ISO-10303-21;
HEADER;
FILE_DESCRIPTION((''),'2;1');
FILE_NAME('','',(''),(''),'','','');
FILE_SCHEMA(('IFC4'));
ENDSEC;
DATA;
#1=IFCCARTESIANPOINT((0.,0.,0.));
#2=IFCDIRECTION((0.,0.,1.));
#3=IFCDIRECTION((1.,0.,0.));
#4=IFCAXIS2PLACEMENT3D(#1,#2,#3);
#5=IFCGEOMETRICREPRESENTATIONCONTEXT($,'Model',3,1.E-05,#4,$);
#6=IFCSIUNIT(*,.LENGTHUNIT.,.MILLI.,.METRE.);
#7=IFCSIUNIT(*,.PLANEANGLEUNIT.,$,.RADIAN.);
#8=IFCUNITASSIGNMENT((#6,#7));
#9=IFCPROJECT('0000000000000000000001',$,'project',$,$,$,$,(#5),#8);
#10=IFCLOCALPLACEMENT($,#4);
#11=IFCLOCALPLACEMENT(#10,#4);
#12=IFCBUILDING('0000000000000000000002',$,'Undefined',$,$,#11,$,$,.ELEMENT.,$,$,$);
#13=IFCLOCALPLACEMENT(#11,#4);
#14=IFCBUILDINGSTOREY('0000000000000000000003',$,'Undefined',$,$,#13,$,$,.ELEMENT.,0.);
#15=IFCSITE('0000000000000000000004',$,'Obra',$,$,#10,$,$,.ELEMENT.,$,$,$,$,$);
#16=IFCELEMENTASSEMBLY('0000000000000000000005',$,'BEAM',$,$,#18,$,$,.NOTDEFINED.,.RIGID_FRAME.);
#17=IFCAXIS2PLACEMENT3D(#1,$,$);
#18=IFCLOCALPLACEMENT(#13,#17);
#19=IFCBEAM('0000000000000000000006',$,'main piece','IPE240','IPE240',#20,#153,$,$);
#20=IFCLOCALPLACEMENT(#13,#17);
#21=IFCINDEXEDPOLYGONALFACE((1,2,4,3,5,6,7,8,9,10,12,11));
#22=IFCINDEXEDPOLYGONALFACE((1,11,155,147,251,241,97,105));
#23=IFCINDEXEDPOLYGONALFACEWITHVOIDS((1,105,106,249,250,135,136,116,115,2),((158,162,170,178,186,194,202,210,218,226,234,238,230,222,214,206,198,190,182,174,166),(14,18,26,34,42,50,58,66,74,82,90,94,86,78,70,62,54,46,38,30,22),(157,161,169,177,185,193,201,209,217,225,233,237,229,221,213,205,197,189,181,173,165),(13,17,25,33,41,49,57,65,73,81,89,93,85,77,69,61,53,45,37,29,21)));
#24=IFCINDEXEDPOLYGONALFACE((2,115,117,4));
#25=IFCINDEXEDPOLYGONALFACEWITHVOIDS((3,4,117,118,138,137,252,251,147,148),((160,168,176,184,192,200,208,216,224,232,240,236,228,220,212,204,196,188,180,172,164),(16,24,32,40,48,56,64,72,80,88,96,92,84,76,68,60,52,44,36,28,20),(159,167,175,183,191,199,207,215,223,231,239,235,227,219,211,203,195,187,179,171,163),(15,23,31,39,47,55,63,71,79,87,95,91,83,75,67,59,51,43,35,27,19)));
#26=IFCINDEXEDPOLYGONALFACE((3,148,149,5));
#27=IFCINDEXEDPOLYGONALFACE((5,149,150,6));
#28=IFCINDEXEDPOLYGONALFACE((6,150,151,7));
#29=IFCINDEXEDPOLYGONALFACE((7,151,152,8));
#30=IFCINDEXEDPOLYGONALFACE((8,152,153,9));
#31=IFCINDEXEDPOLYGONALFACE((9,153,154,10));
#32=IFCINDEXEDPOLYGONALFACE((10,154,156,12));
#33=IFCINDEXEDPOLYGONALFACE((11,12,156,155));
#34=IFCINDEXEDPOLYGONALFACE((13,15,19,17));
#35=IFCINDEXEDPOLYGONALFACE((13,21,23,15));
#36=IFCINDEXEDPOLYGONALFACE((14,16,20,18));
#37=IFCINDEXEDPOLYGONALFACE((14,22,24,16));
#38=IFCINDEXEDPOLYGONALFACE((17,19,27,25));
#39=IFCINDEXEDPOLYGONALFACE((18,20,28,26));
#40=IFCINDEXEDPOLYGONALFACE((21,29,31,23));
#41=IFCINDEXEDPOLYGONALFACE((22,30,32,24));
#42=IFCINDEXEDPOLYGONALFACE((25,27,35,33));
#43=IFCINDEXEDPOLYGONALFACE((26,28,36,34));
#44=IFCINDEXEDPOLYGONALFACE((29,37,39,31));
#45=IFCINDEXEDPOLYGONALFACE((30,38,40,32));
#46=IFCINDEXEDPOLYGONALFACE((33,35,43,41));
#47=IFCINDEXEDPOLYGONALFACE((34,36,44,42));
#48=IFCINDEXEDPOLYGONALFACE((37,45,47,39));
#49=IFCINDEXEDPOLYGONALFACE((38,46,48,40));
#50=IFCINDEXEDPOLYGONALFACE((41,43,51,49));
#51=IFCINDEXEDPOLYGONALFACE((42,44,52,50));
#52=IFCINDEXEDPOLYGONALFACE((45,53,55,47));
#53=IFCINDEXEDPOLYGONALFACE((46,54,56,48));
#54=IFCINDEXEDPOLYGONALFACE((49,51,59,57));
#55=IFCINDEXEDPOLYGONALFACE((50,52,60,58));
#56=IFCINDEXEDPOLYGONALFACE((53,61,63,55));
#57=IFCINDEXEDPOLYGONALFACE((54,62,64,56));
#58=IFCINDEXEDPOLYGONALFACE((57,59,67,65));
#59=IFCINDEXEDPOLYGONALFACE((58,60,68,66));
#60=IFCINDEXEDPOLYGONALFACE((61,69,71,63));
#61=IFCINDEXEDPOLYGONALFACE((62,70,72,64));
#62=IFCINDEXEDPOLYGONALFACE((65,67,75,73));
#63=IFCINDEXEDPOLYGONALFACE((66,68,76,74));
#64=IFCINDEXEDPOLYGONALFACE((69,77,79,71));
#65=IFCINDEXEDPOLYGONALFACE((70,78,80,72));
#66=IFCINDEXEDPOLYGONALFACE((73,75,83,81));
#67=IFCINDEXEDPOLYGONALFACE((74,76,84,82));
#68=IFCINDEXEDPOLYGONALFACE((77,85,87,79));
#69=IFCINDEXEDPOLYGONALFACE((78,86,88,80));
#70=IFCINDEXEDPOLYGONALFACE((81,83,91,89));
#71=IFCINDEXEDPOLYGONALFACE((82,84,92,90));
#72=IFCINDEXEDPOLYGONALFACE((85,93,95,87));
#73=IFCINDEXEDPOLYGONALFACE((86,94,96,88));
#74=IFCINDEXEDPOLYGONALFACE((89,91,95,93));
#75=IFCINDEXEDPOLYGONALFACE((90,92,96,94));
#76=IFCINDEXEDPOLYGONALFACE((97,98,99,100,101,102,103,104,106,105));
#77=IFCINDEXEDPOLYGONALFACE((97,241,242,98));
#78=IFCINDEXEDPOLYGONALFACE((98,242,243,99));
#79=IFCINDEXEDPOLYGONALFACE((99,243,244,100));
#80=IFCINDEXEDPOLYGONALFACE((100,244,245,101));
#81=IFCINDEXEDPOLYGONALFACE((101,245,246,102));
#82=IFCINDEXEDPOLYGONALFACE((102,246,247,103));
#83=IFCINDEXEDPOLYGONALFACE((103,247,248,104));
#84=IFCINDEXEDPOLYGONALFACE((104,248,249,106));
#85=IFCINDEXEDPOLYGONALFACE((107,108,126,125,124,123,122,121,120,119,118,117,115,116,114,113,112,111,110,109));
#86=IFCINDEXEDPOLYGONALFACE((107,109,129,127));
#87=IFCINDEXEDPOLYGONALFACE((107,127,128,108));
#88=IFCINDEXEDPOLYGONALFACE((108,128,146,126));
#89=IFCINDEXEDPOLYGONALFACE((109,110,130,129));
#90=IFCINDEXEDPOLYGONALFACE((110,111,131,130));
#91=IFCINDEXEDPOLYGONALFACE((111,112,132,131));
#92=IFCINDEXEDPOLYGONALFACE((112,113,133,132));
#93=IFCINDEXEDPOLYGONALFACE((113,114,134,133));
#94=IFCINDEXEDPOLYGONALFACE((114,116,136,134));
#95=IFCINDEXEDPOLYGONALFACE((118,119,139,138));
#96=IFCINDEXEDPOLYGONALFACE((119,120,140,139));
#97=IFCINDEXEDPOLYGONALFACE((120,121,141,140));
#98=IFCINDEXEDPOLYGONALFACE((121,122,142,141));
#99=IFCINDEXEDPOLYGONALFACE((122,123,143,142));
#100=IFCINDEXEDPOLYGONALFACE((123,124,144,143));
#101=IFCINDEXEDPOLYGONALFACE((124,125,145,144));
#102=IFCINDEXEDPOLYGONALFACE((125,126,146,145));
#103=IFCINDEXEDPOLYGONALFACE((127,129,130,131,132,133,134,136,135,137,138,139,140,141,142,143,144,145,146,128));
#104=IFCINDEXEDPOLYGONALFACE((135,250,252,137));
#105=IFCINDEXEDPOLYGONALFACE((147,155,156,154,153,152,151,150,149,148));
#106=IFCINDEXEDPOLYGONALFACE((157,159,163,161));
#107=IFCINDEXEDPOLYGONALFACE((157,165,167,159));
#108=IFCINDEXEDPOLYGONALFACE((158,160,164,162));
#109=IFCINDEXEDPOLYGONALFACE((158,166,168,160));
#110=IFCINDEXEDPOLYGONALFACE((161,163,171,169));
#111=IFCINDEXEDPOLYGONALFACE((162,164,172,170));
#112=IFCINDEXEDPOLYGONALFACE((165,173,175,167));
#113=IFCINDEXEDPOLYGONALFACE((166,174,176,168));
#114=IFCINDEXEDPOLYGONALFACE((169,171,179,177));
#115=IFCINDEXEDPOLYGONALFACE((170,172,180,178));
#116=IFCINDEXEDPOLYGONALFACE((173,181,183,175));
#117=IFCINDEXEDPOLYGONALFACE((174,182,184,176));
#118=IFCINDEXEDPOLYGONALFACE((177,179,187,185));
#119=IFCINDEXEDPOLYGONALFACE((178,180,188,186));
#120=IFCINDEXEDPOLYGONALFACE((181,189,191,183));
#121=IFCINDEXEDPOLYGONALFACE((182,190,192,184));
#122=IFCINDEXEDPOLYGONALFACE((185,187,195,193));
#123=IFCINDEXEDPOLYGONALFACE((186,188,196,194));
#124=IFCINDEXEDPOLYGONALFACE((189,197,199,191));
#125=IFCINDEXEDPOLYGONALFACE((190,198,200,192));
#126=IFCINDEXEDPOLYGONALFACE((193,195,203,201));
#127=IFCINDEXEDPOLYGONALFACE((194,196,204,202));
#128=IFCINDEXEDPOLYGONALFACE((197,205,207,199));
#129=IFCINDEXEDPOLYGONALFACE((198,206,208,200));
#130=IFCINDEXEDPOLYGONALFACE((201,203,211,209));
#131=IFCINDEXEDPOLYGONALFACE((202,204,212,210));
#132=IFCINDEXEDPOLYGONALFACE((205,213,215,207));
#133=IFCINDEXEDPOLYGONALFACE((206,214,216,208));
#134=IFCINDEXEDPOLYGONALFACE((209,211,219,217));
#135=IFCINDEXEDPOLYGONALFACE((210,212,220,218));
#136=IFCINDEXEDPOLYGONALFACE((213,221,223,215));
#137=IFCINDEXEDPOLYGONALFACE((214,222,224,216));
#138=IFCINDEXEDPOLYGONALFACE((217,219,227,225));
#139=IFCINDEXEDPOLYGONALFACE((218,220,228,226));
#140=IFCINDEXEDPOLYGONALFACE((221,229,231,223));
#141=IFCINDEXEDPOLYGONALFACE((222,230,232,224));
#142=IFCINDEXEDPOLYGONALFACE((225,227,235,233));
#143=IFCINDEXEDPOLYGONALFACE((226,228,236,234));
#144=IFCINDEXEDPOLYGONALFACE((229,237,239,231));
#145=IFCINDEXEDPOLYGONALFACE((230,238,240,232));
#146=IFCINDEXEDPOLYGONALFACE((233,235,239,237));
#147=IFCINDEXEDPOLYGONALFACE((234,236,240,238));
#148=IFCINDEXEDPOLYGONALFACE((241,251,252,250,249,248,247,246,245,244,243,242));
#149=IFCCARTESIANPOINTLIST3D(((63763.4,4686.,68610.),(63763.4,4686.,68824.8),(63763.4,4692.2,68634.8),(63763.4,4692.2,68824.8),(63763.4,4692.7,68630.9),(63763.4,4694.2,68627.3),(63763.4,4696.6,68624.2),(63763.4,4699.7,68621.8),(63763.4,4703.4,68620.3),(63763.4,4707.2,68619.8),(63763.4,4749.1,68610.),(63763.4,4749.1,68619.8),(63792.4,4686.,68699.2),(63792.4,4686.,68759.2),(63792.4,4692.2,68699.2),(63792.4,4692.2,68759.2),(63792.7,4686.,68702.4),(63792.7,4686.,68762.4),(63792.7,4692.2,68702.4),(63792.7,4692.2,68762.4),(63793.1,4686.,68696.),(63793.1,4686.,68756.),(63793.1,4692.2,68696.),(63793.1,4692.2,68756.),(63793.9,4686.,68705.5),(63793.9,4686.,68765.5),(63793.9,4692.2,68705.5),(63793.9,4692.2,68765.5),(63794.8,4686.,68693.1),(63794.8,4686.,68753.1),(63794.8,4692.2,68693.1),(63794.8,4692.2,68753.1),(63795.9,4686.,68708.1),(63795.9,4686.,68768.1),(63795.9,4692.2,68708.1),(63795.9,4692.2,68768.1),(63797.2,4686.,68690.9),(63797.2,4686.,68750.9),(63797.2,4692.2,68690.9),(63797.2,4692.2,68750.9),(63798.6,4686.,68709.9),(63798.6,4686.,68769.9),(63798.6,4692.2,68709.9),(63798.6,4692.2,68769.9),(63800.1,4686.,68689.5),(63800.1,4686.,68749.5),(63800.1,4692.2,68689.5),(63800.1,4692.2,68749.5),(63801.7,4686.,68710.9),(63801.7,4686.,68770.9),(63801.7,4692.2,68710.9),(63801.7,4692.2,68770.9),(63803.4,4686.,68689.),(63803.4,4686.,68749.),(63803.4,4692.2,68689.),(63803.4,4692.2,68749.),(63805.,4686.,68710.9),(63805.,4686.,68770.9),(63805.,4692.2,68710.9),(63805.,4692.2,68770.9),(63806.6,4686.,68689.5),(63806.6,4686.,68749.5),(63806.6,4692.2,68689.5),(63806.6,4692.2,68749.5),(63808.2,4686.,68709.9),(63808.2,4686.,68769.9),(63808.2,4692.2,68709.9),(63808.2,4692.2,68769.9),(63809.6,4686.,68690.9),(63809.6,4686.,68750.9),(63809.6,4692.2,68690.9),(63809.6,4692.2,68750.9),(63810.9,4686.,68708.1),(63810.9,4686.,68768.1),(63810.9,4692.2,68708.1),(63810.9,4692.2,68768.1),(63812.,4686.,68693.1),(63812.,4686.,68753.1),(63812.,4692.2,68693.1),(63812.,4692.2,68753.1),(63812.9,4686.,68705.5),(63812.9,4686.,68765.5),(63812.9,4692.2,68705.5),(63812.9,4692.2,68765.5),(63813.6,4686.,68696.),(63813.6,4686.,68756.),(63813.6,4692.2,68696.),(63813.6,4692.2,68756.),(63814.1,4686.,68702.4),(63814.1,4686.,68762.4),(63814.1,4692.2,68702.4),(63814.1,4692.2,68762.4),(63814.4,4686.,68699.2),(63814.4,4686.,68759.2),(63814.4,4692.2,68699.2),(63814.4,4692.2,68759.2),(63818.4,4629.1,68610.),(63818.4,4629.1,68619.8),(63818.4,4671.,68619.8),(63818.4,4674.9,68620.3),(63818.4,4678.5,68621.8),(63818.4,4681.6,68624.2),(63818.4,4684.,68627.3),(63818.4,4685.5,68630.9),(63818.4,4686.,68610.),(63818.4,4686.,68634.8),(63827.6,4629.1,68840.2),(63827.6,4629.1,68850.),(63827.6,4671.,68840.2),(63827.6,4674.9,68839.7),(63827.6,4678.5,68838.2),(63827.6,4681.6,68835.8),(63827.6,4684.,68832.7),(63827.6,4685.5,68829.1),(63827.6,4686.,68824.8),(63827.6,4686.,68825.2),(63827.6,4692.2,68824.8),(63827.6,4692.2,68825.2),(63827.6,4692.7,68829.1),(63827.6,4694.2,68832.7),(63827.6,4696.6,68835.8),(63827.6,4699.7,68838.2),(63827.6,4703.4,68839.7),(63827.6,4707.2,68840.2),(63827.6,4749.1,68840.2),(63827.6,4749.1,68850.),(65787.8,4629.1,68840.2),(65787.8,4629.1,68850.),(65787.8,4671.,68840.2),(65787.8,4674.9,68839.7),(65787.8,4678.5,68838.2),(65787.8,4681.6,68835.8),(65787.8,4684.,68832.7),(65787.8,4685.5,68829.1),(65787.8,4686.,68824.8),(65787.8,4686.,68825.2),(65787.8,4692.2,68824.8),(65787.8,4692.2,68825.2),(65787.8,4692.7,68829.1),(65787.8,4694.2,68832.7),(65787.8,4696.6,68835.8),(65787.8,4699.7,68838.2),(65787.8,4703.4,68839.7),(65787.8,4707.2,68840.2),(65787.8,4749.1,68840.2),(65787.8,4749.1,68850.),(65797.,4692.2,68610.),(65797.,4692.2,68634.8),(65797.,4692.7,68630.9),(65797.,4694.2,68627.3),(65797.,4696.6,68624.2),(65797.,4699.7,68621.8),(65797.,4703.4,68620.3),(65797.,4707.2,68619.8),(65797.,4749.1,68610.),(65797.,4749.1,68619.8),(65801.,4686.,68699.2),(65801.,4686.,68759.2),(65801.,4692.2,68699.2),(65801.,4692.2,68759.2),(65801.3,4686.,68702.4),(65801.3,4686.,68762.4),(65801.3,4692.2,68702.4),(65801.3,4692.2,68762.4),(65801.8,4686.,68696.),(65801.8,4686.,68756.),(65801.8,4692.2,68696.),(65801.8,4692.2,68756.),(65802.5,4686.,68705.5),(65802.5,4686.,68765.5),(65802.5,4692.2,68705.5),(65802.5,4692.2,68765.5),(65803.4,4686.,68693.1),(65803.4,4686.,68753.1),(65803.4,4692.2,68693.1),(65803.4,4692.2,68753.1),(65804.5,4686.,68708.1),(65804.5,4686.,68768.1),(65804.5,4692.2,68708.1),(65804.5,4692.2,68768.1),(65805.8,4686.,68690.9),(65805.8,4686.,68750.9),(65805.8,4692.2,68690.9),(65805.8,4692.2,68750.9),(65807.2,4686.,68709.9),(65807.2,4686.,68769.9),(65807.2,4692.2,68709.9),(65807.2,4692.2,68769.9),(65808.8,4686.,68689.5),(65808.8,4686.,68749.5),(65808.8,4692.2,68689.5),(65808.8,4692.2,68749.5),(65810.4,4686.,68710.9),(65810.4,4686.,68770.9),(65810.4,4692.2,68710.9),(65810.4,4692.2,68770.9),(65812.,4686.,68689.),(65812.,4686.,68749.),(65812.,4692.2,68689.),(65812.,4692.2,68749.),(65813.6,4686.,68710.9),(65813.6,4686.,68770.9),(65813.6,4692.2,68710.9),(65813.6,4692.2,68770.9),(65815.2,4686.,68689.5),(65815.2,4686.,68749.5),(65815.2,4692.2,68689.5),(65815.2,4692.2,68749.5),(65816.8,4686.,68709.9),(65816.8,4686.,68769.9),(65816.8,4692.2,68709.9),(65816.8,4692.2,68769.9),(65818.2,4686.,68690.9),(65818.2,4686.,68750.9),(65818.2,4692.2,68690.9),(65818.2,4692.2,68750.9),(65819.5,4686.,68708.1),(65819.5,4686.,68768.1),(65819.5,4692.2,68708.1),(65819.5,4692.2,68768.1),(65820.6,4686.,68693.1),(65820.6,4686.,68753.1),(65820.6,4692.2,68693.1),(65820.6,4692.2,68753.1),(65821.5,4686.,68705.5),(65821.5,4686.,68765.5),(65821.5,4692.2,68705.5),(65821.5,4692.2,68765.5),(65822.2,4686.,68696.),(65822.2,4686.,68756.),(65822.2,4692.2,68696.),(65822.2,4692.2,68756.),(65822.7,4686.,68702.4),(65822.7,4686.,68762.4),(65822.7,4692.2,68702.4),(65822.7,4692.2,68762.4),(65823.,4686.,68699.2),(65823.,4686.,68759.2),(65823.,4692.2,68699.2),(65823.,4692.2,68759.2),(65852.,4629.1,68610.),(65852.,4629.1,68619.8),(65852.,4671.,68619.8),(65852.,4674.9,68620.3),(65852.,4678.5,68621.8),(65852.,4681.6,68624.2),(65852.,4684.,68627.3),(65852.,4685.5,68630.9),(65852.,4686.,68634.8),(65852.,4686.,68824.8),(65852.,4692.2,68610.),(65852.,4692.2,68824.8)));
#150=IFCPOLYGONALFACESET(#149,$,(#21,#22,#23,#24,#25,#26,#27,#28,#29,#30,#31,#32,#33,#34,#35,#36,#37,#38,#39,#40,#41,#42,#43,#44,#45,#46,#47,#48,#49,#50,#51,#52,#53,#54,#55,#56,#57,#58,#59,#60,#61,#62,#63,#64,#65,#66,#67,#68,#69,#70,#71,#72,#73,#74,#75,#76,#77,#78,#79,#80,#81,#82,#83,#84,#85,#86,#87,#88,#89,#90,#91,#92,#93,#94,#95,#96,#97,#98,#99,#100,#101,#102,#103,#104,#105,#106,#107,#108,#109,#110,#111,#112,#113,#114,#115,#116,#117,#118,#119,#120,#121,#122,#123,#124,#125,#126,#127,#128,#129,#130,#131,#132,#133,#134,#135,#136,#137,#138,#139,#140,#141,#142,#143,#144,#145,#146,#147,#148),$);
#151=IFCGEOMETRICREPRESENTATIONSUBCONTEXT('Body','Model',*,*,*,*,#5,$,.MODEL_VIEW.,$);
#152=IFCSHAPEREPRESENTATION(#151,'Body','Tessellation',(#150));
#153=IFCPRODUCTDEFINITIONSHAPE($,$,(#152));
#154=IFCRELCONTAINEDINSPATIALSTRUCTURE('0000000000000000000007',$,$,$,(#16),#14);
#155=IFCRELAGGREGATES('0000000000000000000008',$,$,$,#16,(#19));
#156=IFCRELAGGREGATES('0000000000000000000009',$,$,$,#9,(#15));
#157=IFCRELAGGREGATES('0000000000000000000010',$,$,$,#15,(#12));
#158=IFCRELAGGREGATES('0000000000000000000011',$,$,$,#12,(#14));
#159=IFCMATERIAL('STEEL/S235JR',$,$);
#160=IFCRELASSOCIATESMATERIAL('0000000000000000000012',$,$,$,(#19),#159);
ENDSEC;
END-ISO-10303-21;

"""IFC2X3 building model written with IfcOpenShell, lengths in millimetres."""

from ifc_helpers import new_model, si_unit, frame, origin_with_axes, origin_2d_with_axis, place, context, subcontext, project, spatial, rectangle, circle, i_section, extrude, clip, halfspace, source, transform, mapped, material, element, aggregate, save


model = new_model("IFC2X3")

# Units and contexts
model_context = context("Model", 3, precision=1e-05, world=origin_with_axes())
body_context = subcontext(model_context, "Body", "Model", "MODEL_VIEW")
ifc_project = project(units=[si_unit("LENGTHUNIT", "METRE", prefix="MILLI"), si_unit("PLANEANGLEUNIT", "RADIAN")], contexts=[model_context])

# Site, building, storey
site_placement = place(None, origin_with_axes())
site = spatial("IfcSite", under=ifc_project, at=site_placement, Name="Obra", CompositionType="ELEMENT")
building_placement = place(site_placement, origin_with_axes())
building = spatial("IfcBuilding", under=site, at=building_placement, Name="Undefined", CompositionType="ELEMENT")
storey_placement = place(building_placement, origin_with_axes())
storey = spatial("IfcBuildingStorey", under=building, at=storey_placement, Name="Undefined", CompositionType="ELEMENT", Elevation=0.0)

# Element assembly, beam, openings
ifc_material_1 = material(Name="STEEL/S235JR")
shared_shape_1 = source(origin_with_axes(), body_context, "Body", "SweptSolid", [
    extrude(circle(Radius=11.0, at=origin_2d_with_axis()), frame((0.0, -3.2, 0.0), z_axis=(0.0, 1.0, 0.0), x_axis=(1.0, 0.0, 0.0)), (0.0, 0.0, 1.0), 6.4),
])
assembly_1_placement = place(storey_placement, origin_with_axes())
assembly_1 = element("IfcElementAssembly", 1, at=assembly_1_placement, inside=storey, Name="BEAM", AssemblyPlace="NOTDEFINED", PredefinedType="RIGID_FRAME")
beam_1_placement = place(assembly_1_placement, frame((65797.8, 4689.1, 68730.0), z_axis=(0.0, 0.0, 1.0), x_axis=(-1.0, 0.0, 0.0)))
beam_1 = element("IfcBeam", 2, at=beam_1_placement, material=ifc_material_1, Name="main piece", Description="IPE240", ObjectType="IPE240", context=body_context, shape_type="Clipping", body=[
    clip(clip(extrude(i_section(OverallWidth=120.0, OverallDepth=240.0, WebThickness=6.2, FlangeThickness=9.8, FilletRadius=15.0, at=origin_2d_with_axis()), frame((2034.4, 0.0, 0.0), z_axis=(-1.0, 0.0, 0.0), x_axis=(0.0, -1.0, 0.0)), (0.0, 0.0, 1.0), 2088.6), halfspace(frame((2034.4, 0.0, -220.0), z_axis=(-1.0, 0.0, 0.0), x_axis=(0.0, 1.0, 0.0)), True)), halfspace(frame((-54.2, 0.0, -220.0), z_axis=(1.0, 0.0, 0.0), x_axis=(0.0, -1.0, 0.0)), True)),
])
opening_1_placement = place(assembly_1_placement, frame((65797.8, 4689.1, 68730.0), z_axis=(0.0, 0.0, 1.0), x_axis=(-1.0, 0.0, 0.0)))
element("IfcOpeningElement", 3, at=opening_1_placement, cuts=beam_1, ObjectType="Recess", context=body_context, shape_type="SweptSolid", body=[
    extrude(rectangle(XDim=65.0, YDim=300.0, at=origin_2d_with_axis()), frame((-31.7, -153.1, 109.8), z_axis=(0.0, 0.0, -1.0), x_axis=(1.0, 0.0, 0.0)), (0.0, 0.0, 1.0), 249.6),
])
opening_2_placement = place(assembly_1_placement, frame((65797.8, 4689.1, 68730.0), z_axis=(0.0, 0.0, 1.0), x_axis=(-1.0, 0.0, 0.0)))
element("IfcOpeningElement", 4, at=opening_2_placement, cuts=beam_1, ObjectType="Recess", context=body_context, shape_type="SweptSolid", body=[
    extrude(rectangle(XDim=26.2, YDim=76.2, at=origin_2d_with_axis()), frame((-28.1, -61.0, 107.9), z_axis=(0.0, 1.0, 0.0), x_axis=(0.0, 0.0, -1.0)), (0.0, 0.0, 1.0), 122.0),
])
opening_3_placement = place(assembly_1_placement, frame((65797.8, 4689.1, 68730.0), z_axis=(0.0, 0.0, 1.0), x_axis=(-1.0, 0.0, 0.0)))
element("IfcOpeningElement", 5, at=opening_3_placement, cuts=beam_1, ObjectType="Recess", context=body_context, shape_type="SweptSolid", body=[
    extrude(rectangle(XDim=65.0, YDim=300.0, at=origin_2d_with_axis()), frame((2011.9, 153.1, 109.8), z_axis=(0.0, 0.0, -1.0), x_axis=(-1.0, 0.0, 0.0)), (0.0, 0.0, 1.0), 249.6),
])
opening_4_placement = place(assembly_1_placement, frame((65797.8, 4689.1, 68730.0), z_axis=(0.0, 0.0, 1.0), x_axis=(-1.0, 0.0, 0.0)))
element("IfcOpeningElement", 6, at=opening_4_placement, cuts=beam_1, ObjectType="Recess", context=body_context, shape_type="SweptSolid", body=[
    extrude(rectangle(XDim=26.2, YDim=76.2, at=origin_2d_with_axis()), frame((2008.3, 61.0, 107.9), z_axis=(0.0, -1.0, 0.0), x_axis=(0.0, 0.0, -1.0)), (0.0, 0.0, 1.0), 122.0),
])
opening_5_placement = place(assembly_1_placement, frame((65852.0, 4689.1, 68850.0), z_axis=(-1.0, 0.0, 0.0), x_axis=(0.0, 0.0, -1.0)))
element("IfcOpeningElement", 7, at=opening_5_placement, cuts=beam_1, ObjectType="Opening", context=body_context, shape_type="MappedRepresentation", body=[
    mapped(shared_shape_1, transform((90.0, 0.0, 40.0))),
    mapped(shared_shape_1, transform((150.0, 0.0, 40.0))),
])
opening_6_placement = place(assembly_1_placement, frame((63763.4, 4689.1, 68850.0), z_axis=(1.0, 0.0, 0.0), x_axis=(0.0, 0.0, -1.0)))
element("IfcOpeningElement", 8, at=opening_6_placement, cuts=beam_1, ObjectType="Opening", context=body_context, shape_type="MappedRepresentation", body=[
    mapped(shared_shape_1, transform((90.0, 0.0, 40.0))),
    mapped(shared_shape_1, transform((150.0, 0.0, 40.0))),
])
aggregate(assembly_1, [beam_1])

save(model, "model.ifc")
